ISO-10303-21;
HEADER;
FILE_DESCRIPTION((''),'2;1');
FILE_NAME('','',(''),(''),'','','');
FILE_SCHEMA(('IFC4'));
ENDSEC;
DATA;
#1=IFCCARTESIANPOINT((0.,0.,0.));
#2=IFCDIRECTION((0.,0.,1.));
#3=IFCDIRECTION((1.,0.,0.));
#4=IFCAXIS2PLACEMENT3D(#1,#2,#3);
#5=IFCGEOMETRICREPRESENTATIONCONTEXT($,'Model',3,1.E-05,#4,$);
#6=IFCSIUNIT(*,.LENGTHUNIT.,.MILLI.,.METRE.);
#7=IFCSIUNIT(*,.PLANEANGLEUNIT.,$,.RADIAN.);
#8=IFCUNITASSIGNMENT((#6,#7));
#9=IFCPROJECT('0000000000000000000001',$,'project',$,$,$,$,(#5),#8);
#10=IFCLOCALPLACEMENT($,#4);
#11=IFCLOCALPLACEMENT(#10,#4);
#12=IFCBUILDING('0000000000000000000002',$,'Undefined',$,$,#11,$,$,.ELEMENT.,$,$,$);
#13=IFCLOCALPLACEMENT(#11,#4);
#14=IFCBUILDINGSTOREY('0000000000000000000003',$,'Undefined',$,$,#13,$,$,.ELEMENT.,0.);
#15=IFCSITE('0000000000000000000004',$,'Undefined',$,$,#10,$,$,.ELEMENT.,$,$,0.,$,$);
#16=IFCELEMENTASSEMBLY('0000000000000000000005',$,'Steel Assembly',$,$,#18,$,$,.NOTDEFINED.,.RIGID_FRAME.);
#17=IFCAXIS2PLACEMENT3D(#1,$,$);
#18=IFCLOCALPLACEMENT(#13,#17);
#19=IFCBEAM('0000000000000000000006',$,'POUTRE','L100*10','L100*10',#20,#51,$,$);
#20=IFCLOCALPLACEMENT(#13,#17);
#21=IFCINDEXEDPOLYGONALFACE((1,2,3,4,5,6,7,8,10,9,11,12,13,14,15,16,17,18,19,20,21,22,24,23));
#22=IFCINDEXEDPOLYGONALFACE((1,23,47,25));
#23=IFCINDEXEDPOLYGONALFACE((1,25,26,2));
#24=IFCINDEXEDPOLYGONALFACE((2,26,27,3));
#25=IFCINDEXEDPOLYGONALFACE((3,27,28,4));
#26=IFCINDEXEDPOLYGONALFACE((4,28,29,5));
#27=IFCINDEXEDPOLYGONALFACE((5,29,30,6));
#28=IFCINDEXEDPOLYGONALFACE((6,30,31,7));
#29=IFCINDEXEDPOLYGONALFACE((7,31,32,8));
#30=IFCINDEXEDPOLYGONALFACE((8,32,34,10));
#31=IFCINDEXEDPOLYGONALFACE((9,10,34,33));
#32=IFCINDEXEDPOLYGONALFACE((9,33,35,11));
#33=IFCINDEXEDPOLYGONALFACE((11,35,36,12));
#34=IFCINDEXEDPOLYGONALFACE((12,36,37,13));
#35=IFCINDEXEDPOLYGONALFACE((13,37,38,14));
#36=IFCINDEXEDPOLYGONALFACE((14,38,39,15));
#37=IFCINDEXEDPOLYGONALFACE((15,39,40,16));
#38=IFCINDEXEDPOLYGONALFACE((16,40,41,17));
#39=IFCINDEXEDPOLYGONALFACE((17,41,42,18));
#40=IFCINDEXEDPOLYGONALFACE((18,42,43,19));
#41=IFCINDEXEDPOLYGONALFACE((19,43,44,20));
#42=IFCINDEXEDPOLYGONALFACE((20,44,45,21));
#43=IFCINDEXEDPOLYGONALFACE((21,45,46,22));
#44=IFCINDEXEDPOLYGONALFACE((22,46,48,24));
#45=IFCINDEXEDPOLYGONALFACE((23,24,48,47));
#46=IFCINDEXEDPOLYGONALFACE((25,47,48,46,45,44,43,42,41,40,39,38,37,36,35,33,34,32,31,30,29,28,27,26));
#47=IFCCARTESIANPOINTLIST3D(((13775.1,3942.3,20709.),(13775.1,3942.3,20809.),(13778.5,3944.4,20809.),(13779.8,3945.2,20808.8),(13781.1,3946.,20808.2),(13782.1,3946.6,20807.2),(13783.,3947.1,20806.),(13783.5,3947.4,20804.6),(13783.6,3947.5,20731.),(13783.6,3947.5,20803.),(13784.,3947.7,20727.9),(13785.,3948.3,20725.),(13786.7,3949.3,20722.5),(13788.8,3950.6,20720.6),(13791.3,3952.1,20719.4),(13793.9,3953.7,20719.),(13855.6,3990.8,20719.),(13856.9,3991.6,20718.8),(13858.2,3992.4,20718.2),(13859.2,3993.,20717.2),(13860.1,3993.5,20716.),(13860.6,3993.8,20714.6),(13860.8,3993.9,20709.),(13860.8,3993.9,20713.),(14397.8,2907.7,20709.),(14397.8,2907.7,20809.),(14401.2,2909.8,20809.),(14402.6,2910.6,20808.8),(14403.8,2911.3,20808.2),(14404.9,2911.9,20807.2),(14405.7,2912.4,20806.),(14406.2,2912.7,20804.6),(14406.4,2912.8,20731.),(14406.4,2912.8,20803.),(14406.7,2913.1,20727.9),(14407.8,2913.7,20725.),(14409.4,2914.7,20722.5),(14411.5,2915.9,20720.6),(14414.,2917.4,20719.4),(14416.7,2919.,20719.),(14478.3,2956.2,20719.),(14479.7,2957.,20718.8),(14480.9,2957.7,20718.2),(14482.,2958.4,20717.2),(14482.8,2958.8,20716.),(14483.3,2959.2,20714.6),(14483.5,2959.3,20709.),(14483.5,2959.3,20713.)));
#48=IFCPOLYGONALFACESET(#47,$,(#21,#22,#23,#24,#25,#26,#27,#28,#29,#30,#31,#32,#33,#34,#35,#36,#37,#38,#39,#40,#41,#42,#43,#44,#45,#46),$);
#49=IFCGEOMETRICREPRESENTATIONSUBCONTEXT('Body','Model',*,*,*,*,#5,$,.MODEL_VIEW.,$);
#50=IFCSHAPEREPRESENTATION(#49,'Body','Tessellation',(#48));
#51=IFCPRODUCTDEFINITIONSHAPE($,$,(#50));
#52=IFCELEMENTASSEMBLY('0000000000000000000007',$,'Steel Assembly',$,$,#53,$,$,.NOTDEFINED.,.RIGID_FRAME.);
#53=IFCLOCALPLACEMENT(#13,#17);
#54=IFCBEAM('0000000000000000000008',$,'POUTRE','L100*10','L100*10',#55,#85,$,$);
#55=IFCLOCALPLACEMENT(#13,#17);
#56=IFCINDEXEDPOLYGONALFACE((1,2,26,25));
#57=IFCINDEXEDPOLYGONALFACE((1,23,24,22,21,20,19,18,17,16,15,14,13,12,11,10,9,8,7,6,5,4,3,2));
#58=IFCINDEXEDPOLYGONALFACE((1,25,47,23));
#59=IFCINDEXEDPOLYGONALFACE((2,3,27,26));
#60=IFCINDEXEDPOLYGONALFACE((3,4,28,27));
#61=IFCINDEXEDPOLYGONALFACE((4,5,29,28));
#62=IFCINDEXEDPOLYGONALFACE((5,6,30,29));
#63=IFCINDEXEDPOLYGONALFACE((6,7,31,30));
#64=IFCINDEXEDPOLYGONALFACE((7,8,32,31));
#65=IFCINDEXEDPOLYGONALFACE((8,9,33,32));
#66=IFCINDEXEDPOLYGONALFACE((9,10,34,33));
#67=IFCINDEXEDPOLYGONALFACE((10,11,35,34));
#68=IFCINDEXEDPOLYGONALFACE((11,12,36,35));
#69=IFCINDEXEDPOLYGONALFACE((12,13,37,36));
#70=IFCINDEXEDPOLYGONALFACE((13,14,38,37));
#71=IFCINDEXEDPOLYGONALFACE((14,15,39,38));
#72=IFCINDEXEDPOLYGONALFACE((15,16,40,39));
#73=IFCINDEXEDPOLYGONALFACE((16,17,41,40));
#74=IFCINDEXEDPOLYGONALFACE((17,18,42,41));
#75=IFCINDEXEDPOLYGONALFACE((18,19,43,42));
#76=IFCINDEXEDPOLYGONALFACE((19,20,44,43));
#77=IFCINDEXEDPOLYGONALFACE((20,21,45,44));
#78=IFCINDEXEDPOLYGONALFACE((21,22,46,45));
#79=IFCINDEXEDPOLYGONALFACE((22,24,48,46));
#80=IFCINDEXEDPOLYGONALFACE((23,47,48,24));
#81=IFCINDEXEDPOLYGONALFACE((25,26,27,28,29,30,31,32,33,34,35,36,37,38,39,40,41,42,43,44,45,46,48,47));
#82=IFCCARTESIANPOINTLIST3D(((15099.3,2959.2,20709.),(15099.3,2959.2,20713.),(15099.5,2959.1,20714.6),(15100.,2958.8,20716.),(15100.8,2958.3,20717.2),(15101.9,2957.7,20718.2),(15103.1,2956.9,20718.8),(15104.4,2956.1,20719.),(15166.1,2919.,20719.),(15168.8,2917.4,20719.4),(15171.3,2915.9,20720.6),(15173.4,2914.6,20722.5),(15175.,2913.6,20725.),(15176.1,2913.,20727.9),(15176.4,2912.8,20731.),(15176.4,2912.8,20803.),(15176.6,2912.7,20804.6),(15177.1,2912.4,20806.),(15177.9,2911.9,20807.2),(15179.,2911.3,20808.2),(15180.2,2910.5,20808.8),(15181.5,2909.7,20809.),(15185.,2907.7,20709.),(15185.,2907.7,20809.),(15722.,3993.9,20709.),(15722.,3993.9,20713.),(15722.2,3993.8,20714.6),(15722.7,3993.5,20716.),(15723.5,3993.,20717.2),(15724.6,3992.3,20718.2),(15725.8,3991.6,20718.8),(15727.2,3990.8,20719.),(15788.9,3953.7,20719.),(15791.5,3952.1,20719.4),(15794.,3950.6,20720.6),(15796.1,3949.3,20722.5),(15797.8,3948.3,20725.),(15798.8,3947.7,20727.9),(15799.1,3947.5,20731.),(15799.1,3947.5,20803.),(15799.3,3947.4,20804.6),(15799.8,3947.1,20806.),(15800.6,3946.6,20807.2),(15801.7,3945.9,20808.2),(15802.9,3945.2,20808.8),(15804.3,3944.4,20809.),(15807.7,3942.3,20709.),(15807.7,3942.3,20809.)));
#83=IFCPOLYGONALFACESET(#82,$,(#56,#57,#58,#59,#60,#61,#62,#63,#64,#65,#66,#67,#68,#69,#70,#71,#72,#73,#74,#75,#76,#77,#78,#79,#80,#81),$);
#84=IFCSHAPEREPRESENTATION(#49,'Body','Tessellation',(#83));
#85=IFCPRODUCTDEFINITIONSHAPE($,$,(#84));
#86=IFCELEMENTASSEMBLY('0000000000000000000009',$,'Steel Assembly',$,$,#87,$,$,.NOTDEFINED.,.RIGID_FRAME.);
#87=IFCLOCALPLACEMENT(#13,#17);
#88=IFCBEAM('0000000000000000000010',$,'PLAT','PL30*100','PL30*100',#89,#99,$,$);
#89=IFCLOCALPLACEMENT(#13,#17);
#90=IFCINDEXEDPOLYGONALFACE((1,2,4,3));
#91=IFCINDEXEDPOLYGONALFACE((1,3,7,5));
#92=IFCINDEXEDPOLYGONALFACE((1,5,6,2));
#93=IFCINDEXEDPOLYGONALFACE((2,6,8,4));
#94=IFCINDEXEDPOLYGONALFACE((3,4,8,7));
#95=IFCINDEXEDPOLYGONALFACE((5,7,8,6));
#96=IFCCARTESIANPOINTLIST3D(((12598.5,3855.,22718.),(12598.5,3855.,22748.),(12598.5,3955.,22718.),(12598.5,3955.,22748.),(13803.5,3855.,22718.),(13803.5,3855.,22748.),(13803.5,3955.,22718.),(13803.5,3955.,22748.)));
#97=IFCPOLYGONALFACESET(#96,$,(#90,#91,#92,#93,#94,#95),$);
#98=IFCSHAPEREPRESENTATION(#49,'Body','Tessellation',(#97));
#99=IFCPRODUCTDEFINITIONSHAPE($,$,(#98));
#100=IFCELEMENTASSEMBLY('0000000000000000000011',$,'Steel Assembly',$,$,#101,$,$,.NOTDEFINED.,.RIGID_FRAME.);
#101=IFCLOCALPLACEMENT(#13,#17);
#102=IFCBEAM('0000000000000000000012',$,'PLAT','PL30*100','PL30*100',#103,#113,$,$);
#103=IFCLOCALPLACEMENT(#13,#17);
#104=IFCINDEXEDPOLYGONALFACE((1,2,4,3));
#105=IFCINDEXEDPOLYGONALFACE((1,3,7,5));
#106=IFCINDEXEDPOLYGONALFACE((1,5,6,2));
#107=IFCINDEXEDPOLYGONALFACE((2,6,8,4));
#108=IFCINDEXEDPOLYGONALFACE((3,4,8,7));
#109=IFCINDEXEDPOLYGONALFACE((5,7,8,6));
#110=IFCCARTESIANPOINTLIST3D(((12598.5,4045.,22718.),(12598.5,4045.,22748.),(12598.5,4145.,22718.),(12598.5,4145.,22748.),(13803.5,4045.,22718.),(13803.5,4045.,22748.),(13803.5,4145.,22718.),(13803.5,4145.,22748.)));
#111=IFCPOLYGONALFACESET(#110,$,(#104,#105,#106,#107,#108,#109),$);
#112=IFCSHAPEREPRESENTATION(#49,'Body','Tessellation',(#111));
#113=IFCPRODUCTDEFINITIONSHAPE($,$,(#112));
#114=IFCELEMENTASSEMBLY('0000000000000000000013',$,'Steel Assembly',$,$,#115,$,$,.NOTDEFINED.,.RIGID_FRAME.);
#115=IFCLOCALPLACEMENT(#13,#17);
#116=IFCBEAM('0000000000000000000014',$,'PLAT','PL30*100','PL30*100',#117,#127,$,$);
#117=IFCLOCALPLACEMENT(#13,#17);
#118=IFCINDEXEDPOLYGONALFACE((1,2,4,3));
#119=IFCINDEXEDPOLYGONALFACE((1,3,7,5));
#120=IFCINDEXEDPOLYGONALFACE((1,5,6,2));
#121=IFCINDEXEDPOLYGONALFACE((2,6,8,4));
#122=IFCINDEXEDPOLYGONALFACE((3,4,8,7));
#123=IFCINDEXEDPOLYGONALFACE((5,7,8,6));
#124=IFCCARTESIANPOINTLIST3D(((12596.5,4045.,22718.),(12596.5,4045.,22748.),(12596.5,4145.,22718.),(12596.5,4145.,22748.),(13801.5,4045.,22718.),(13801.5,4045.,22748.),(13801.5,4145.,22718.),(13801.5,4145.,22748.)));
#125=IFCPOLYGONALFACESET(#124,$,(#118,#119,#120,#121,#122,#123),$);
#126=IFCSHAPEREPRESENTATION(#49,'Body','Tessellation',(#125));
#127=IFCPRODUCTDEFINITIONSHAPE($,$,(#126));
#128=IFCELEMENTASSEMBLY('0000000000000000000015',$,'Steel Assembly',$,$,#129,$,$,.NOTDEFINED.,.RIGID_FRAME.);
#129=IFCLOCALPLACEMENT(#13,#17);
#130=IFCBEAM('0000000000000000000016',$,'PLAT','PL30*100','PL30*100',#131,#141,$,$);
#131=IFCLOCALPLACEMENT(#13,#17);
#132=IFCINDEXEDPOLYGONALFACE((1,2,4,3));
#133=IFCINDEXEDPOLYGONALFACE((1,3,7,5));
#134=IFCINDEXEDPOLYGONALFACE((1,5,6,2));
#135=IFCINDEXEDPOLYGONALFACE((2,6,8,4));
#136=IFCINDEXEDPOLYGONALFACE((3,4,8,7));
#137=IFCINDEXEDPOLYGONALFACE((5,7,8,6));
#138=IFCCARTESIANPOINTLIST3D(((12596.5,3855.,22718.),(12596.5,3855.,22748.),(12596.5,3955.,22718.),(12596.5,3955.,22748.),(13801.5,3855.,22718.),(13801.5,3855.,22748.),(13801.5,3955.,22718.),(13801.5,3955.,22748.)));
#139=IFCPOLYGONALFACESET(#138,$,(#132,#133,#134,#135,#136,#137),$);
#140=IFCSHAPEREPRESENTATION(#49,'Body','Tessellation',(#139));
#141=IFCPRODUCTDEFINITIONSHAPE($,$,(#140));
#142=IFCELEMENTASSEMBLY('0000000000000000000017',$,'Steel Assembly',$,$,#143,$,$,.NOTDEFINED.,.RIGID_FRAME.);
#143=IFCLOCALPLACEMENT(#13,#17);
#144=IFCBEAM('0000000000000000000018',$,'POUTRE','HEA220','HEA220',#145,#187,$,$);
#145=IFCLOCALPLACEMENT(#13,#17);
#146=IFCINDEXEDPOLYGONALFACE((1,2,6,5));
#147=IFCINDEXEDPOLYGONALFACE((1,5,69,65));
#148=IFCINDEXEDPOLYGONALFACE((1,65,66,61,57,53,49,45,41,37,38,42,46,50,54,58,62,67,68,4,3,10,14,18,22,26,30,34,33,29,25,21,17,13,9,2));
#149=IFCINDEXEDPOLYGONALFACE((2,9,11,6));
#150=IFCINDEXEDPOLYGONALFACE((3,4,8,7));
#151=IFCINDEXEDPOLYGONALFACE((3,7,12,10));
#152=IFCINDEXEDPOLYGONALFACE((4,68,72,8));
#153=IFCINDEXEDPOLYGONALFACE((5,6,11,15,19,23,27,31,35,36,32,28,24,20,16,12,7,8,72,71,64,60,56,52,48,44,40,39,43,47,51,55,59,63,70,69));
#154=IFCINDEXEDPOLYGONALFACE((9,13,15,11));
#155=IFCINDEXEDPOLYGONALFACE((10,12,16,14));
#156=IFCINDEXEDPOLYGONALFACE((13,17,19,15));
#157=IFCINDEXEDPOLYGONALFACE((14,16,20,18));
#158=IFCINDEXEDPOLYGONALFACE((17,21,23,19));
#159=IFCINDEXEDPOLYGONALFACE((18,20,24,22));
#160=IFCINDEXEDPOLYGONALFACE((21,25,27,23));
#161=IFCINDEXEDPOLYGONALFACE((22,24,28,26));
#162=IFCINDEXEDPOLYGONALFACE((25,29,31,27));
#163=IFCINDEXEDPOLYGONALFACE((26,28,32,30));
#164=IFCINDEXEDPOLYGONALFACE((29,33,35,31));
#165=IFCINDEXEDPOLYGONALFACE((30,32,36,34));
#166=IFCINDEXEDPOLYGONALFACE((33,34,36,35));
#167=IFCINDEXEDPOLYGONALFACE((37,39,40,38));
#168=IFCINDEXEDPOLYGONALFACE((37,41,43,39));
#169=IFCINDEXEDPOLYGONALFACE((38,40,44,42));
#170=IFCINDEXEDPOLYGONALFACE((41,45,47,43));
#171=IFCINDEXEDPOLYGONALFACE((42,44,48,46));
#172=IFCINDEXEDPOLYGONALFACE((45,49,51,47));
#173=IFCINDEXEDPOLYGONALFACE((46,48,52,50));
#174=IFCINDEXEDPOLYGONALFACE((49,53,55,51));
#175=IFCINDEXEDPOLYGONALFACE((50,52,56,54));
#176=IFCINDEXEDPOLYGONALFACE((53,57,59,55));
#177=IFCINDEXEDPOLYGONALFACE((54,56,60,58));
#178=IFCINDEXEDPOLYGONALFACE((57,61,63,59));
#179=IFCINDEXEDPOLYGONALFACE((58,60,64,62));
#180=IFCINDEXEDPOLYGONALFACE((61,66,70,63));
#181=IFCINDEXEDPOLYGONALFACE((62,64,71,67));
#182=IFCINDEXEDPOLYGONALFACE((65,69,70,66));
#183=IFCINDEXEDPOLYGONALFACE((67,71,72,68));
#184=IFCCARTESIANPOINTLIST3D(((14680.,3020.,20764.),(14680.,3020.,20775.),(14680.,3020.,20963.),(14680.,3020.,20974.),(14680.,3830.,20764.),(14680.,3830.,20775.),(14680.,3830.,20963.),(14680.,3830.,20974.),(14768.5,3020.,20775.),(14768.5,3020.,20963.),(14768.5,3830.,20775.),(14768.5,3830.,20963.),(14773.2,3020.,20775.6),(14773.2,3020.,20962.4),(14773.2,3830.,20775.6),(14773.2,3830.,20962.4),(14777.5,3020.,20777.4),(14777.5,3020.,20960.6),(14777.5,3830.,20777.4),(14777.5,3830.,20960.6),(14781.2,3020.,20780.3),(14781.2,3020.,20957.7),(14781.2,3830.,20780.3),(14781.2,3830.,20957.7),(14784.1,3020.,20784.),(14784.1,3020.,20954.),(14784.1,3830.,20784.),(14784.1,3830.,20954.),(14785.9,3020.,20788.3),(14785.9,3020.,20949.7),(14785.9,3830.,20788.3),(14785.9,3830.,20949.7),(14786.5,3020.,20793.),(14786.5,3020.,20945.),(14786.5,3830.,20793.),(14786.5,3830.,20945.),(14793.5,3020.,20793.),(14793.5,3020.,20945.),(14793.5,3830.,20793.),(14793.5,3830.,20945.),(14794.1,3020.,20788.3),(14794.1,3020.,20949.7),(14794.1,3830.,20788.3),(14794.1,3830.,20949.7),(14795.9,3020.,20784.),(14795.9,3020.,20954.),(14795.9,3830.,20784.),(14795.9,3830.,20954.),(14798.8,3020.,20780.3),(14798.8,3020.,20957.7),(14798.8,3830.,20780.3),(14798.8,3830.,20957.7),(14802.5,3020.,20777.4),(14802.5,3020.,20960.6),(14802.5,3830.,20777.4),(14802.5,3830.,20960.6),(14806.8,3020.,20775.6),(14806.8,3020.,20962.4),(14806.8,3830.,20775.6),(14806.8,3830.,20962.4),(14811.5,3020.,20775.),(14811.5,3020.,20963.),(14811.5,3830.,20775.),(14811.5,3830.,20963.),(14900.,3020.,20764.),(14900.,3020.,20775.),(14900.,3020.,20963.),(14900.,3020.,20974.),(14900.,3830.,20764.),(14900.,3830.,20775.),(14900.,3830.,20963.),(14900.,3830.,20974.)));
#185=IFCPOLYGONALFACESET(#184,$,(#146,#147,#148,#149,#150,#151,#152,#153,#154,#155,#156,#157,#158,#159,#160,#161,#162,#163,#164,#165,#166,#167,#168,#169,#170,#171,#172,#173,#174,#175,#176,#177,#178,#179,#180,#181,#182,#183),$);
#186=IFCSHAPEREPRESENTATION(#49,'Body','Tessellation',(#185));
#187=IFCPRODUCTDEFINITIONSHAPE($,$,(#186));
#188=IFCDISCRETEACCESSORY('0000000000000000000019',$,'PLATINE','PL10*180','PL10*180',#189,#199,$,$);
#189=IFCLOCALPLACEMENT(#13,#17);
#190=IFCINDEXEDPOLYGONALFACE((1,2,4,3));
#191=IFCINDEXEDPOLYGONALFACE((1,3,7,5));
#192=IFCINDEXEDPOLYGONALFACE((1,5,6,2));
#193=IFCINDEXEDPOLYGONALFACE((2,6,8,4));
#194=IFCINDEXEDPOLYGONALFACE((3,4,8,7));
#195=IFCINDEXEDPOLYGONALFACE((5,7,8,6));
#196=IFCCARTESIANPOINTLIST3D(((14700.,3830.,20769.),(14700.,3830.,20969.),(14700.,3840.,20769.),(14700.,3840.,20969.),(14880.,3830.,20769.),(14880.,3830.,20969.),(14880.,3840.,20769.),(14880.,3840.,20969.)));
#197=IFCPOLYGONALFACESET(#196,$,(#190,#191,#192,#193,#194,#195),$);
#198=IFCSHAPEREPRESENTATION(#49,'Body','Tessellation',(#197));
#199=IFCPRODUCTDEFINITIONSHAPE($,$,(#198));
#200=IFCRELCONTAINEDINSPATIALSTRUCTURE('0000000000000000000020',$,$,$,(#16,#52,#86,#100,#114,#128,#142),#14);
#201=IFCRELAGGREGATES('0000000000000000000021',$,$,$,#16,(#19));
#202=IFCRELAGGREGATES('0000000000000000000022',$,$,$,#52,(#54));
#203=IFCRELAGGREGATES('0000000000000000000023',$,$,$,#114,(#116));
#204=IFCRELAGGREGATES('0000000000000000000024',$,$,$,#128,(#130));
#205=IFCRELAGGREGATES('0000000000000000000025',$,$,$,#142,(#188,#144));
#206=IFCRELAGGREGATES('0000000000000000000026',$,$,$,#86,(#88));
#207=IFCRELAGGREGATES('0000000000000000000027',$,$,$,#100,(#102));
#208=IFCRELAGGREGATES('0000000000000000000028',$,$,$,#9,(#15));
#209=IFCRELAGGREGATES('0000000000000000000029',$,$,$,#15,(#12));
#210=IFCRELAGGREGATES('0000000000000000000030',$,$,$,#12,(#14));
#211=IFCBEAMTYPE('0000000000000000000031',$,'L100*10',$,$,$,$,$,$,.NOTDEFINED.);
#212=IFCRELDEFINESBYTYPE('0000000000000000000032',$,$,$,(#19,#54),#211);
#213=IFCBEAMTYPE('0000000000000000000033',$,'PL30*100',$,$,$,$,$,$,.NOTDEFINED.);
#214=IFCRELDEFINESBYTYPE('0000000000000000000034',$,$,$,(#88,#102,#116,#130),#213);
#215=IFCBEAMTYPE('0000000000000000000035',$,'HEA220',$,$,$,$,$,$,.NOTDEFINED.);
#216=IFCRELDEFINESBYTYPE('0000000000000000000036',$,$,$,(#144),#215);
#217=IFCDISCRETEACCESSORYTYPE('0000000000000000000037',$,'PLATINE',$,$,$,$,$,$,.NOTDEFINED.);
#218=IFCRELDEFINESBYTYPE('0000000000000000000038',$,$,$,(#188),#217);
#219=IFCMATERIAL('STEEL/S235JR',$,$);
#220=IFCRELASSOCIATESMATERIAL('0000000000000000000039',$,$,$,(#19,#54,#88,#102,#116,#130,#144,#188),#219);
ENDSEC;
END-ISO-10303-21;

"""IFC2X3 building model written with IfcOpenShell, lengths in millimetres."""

from ifc_helpers import new_model, si_unit, frame, origin_with_axes, origin_2d_with_axis, place, context, subcontext, project, spatial, polyline, rectangle, i_section, l_section, outline, extrude, material, type_object, element, aggregate, save


model = new_model("IFC2X3")

# Units and contexts
model_context = context("Model", 3, precision=1e-05, world=origin_with_axes())
body_context = subcontext(model_context, "Body", "Model", "MODEL_VIEW")
ifc_project = project(units=[si_unit("LENGTHUNIT", "METRE", prefix="MILLI"), si_unit("PLANEANGLEUNIT", "RADIAN")], contexts=[model_context])

# Site, building, storey
site_placement = place(None, origin_with_axes())
site = spatial("IfcSite", under=ifc_project, at=site_placement, Name="Undefined", CompositionType="ELEMENT", RefElevation=0.0)
building_placement = place(site_placement, origin_with_axes())
building = spatial("IfcBuilding", under=site, at=building_placement, Name="Undefined", CompositionType="ELEMENT")
storey_placement = place(building_placement, origin_with_axes())
storey = spatial("IfcBuildingStorey", under=building, at=storey_placement, Name="Undefined", CompositionType="ELEMENT", Elevation=0.0)

# Element assemblies, beams
assembly_1_placement = place(storey_placement, origin_with_axes())
assembly_1 = element("IfcElementAssembly", 1, at=assembly_1_placement, inside=storey, Name="Steel Assembly", AssemblyPlace="NOTDEFINED", PredefinedType="RIGID_FRAME")
ifc_material_1 = material(Name="STEEL/S235JR")
beam_type_1 = type_object("IfcBeamType", Name="L100*10", PredefinedType="NOTDEFINED")
beam_1_placement = place(assembly_1_placement, frame((14440.7, 2933.4, 20759.0), z_axis=(0.0, 0.0, 1.0), x_axis=(-0.515676, 0.856783, 0.0)))
beam_1 = element("IfcBeam", 2, at=beam_1_placement, type_object=beam_type_1, material=ifc_material_1, Name="POUTRE", Description="L100*10", ObjectType="L100*10", context=body_context, shape_type="SweptSolid", body=[
    extrude(l_section(Depth=100.0, Width=100.0, Thickness=10.0, FilletRadius=12.0, EdgeRadius=6.0, at=origin_2d_with_axis()), frame((1207.6, 0.0, 0.0), z_axis=(-1.0, 0.0, 0.0), x_axis=(0.0, -1.0, 0.0)), (0.0, 0.0, 1.0), 1207.6),
])
aggregate(assembly_1, [beam_1])
assembly_2_placement = place(storey_placement, origin_with_axes())
assembly_2 = element("IfcElementAssembly", 3, at=assembly_2_placement, inside=storey, Name="Steel Assembly", AssemblyPlace="NOTDEFINED", PredefinedType="RIGID_FRAME")
beam_2_placement = place(assembly_2_placement, frame((15764.9, 3968.1, 20759.0), z_axis=(0.0, 0.0, 1.0), x_axis=(-0.515676, -0.856783, 0.0)))
beam_2 = element("IfcBeam", 4, at=beam_2_placement, type_object=beam_type_1, material=ifc_material_1, Name="POUTRE", Description="L100*10", ObjectType="L100*10", context=body_context, shape_type="SweptSolid", body=[
    extrude(l_section(Depth=100.0, Width=100.0, Thickness=10.0, FilletRadius=12.0, EdgeRadius=6.0, at=origin_2d_with_axis()), frame((1207.6, 0.0, 0.0), z_axis=(-1.0, 0.0, 0.0), x_axis=(0.0, -1.0, 0.0)), (0.0, 0.0, 1.0), 1207.6),
])
aggregate(assembly_2, [beam_2])
assembly_3_placement = place(storey_placement, origin_with_axes())
assembly_3 = element("IfcElementAssembly", 5, at=assembly_3_placement, inside=storey, Name="Steel Assembly", AssemblyPlace="NOTDEFINED", PredefinedType="RIGID_FRAME")
beam_type_2 = type_object("IfcBeamType", Name="PL30*100", PredefinedType="NOTDEFINED")
beam_3_placement = place(assembly_3_placement, frame((12598.5, 3905.0, 22733.0), z_axis=(0.0, 1.0, 0.0), x_axis=(1.0, 0.0, 0.0)))
beam_3 = element("IfcBeam", 6, at=beam_3_placement, type_object=beam_type_2, material=ifc_material_1, Name="PLAT", Description="PL30*100", ObjectType="PL30*100", context=body_context, shape_type="SweptSolid", body=[
    extrude(rectangle(XDim=30.0, YDim=100.0, at=origin_2d_with_axis()), frame((1205.0, 0.0, 0.0), z_axis=(-1.0, 0.0, 0.0), x_axis=(0.0, -1.0, 0.0)), (0.0, 0.0, 1.0), 1205.0),
])
assembly_4_placement = place(storey_placement, origin_with_axes())
assembly_4 = element("IfcElementAssembly", 7, at=assembly_4_placement, inside=storey, Name="Steel Assembly", AssemblyPlace="NOTDEFINED", PredefinedType="RIGID_FRAME")
beam_4_placement = place(assembly_4_placement, frame((12598.5, 4095.0, 22733.0), z_axis=(0.0, 1.0, 0.0), x_axis=(1.0, 0.0, 0.0)))
beam_4 = element("IfcBeam", 8, at=beam_4_placement, type_object=beam_type_2, material=ifc_material_1, Name="PLAT", Description="PL30*100", ObjectType="PL30*100", context=body_context, shape_type="SweptSolid", body=[
    extrude(rectangle(XDim=30.0, YDim=100.0, at=origin_2d_with_axis()), frame((1205.0, 0.0, 0.0), z_axis=(-1.0, 0.0, 0.0), x_axis=(0.0, -1.0, 0.0)), (0.0, 0.0, 1.0), 1205.0),
])
assembly_5_placement = place(storey_placement, origin_with_axes())
assembly_5 = element("IfcElementAssembly", 9, at=assembly_5_placement, inside=storey, Name="Steel Assembly", AssemblyPlace="NOTDEFINED", PredefinedType="RIGID_FRAME")
beam_5_placement = place(assembly_5_placement, frame((13801.5, 4095.0, 22733.0), z_axis=(0.0, -1.0, 0.0), x_axis=(-1.0, 0.0, 0.0)))
beam_5 = element("IfcBeam", 10, at=beam_5_placement, type_object=beam_type_2, material=ifc_material_1, Name="PLAT", Description="PL30*100", ObjectType="PL30*100", context=body_context, shape_type="SweptSolid", body=[
    extrude(rectangle(XDim=30.0, YDim=100.0, at=origin_2d_with_axis()), frame((1205.0, 0.0, 0.0), z_axis=(-1.0, 0.0, 0.0), x_axis=(0.0, -1.0, 0.0)), (0.0, 0.0, 1.0), 1205.0),
])
aggregate(assembly_5, [beam_5])
assembly_6_placement = place(storey_placement, origin_with_axes())
assembly_6 = element("IfcElementAssembly", 11, at=assembly_6_placement, inside=storey, Name="Steel Assembly", AssemblyPlace="NOTDEFINED", PredefinedType="RIGID_FRAME")
beam_6_placement = place(assembly_6_placement, frame((13801.5, 3905.0, 22733.0), z_axis=(0.0, -1.0, 0.0), x_axis=(-1.0, 0.0, 0.0)))
beam_6 = element("IfcBeam", 12, at=beam_6_placement, type_object=beam_type_2, material=ifc_material_1, Name="PLAT", Description="PL30*100", ObjectType="PL30*100", context=body_context, shape_type="SweptSolid", body=[
    extrude(rectangle(XDim=30.0, YDim=100.0, at=origin_2d_with_axis()), frame((1205.0, 0.0, 0.0), z_axis=(-1.0, 0.0, 0.0), x_axis=(0.0, -1.0, 0.0)), (0.0, 0.0, 1.0), 1205.0),
])
aggregate(assembly_6, [beam_6])

# Element assembly, beam
assembly_7_placement = place(storey_placement, origin_with_axes())
assembly_7 = element("IfcElementAssembly", 13, at=assembly_7_placement, inside=storey, Name="Steel Assembly", AssemblyPlace="NOTDEFINED", PredefinedType="RIGID_FRAME")
beam_type_3 = type_object("IfcBeamType", Name="HEA220", PredefinedType="NOTDEFINED")
beam_7_placement = place(assembly_7_placement, frame((14790.0, 3850.0, 20869.0), z_axis=(0.0, 0.0, 1.0), x_axis=(0.0, -1.0, 0.0)))
beam_7 = element("IfcBeam", 14, at=beam_7_placement, type_object=beam_type_3, material=ifc_material_1, Name="POUTRE", Description="HEA220", ObjectType="HEA220", context=body_context, shape_type="SweptSolid", body=[
    extrude(i_section(OverallWidth=220.0, OverallDepth=210.0, WebThickness=7.0, FlangeThickness=11.0, FilletRadius=18.0, at=origin_2d_with_axis()), frame((830.0, 0.0, 0.0), z_axis=(-1.0, 0.0, 0.0), x_axis=(0.0, -1.0, 0.0)), (0.0, 0.0, 1.0), 810.0),
])

# Discrete accessory
discrete_accessory_type_1 = type_object("IfcDiscreteAccessoryType", Name="PLATINE")
discrete_accessory_1_placement = place(assembly_7_placement, frame((14790.0, 3835.0, 20769.0), z_axis=(0.0, -1.0, 0.0), x_axis=(0.0, 0.0, 1.0)))
discrete_accessory_1 = element("IfcDiscreteAccessory", 15, at=discrete_accessory_1_placement, type_object=discrete_accessory_type_1, material=ifc_material_1, Name="PLATINE", Description="PL10*180", ObjectType="PL10*180", context=body_context, shape_type="SweptSolid", body=[
    extrude(outline(polyline([(200.0, 90.0), (200.0, -90.0), (0.0, -90.0), (0.0, 90.0), (200.0, 90.0)])), frame((0.0, 0.0, -5.0), z_axis=(0.0, 0.0, 1.0), x_axis=(1.0, 0.0, 0.0)), (0.0, 0.0, 1.0), 10.0),
])
aggregate(assembly_7, [discrete_accessory_1, beam_7])

aggregate(assembly_3, [beam_3])
aggregate(assembly_4, [beam_4])

save(model, "model.ifc")
